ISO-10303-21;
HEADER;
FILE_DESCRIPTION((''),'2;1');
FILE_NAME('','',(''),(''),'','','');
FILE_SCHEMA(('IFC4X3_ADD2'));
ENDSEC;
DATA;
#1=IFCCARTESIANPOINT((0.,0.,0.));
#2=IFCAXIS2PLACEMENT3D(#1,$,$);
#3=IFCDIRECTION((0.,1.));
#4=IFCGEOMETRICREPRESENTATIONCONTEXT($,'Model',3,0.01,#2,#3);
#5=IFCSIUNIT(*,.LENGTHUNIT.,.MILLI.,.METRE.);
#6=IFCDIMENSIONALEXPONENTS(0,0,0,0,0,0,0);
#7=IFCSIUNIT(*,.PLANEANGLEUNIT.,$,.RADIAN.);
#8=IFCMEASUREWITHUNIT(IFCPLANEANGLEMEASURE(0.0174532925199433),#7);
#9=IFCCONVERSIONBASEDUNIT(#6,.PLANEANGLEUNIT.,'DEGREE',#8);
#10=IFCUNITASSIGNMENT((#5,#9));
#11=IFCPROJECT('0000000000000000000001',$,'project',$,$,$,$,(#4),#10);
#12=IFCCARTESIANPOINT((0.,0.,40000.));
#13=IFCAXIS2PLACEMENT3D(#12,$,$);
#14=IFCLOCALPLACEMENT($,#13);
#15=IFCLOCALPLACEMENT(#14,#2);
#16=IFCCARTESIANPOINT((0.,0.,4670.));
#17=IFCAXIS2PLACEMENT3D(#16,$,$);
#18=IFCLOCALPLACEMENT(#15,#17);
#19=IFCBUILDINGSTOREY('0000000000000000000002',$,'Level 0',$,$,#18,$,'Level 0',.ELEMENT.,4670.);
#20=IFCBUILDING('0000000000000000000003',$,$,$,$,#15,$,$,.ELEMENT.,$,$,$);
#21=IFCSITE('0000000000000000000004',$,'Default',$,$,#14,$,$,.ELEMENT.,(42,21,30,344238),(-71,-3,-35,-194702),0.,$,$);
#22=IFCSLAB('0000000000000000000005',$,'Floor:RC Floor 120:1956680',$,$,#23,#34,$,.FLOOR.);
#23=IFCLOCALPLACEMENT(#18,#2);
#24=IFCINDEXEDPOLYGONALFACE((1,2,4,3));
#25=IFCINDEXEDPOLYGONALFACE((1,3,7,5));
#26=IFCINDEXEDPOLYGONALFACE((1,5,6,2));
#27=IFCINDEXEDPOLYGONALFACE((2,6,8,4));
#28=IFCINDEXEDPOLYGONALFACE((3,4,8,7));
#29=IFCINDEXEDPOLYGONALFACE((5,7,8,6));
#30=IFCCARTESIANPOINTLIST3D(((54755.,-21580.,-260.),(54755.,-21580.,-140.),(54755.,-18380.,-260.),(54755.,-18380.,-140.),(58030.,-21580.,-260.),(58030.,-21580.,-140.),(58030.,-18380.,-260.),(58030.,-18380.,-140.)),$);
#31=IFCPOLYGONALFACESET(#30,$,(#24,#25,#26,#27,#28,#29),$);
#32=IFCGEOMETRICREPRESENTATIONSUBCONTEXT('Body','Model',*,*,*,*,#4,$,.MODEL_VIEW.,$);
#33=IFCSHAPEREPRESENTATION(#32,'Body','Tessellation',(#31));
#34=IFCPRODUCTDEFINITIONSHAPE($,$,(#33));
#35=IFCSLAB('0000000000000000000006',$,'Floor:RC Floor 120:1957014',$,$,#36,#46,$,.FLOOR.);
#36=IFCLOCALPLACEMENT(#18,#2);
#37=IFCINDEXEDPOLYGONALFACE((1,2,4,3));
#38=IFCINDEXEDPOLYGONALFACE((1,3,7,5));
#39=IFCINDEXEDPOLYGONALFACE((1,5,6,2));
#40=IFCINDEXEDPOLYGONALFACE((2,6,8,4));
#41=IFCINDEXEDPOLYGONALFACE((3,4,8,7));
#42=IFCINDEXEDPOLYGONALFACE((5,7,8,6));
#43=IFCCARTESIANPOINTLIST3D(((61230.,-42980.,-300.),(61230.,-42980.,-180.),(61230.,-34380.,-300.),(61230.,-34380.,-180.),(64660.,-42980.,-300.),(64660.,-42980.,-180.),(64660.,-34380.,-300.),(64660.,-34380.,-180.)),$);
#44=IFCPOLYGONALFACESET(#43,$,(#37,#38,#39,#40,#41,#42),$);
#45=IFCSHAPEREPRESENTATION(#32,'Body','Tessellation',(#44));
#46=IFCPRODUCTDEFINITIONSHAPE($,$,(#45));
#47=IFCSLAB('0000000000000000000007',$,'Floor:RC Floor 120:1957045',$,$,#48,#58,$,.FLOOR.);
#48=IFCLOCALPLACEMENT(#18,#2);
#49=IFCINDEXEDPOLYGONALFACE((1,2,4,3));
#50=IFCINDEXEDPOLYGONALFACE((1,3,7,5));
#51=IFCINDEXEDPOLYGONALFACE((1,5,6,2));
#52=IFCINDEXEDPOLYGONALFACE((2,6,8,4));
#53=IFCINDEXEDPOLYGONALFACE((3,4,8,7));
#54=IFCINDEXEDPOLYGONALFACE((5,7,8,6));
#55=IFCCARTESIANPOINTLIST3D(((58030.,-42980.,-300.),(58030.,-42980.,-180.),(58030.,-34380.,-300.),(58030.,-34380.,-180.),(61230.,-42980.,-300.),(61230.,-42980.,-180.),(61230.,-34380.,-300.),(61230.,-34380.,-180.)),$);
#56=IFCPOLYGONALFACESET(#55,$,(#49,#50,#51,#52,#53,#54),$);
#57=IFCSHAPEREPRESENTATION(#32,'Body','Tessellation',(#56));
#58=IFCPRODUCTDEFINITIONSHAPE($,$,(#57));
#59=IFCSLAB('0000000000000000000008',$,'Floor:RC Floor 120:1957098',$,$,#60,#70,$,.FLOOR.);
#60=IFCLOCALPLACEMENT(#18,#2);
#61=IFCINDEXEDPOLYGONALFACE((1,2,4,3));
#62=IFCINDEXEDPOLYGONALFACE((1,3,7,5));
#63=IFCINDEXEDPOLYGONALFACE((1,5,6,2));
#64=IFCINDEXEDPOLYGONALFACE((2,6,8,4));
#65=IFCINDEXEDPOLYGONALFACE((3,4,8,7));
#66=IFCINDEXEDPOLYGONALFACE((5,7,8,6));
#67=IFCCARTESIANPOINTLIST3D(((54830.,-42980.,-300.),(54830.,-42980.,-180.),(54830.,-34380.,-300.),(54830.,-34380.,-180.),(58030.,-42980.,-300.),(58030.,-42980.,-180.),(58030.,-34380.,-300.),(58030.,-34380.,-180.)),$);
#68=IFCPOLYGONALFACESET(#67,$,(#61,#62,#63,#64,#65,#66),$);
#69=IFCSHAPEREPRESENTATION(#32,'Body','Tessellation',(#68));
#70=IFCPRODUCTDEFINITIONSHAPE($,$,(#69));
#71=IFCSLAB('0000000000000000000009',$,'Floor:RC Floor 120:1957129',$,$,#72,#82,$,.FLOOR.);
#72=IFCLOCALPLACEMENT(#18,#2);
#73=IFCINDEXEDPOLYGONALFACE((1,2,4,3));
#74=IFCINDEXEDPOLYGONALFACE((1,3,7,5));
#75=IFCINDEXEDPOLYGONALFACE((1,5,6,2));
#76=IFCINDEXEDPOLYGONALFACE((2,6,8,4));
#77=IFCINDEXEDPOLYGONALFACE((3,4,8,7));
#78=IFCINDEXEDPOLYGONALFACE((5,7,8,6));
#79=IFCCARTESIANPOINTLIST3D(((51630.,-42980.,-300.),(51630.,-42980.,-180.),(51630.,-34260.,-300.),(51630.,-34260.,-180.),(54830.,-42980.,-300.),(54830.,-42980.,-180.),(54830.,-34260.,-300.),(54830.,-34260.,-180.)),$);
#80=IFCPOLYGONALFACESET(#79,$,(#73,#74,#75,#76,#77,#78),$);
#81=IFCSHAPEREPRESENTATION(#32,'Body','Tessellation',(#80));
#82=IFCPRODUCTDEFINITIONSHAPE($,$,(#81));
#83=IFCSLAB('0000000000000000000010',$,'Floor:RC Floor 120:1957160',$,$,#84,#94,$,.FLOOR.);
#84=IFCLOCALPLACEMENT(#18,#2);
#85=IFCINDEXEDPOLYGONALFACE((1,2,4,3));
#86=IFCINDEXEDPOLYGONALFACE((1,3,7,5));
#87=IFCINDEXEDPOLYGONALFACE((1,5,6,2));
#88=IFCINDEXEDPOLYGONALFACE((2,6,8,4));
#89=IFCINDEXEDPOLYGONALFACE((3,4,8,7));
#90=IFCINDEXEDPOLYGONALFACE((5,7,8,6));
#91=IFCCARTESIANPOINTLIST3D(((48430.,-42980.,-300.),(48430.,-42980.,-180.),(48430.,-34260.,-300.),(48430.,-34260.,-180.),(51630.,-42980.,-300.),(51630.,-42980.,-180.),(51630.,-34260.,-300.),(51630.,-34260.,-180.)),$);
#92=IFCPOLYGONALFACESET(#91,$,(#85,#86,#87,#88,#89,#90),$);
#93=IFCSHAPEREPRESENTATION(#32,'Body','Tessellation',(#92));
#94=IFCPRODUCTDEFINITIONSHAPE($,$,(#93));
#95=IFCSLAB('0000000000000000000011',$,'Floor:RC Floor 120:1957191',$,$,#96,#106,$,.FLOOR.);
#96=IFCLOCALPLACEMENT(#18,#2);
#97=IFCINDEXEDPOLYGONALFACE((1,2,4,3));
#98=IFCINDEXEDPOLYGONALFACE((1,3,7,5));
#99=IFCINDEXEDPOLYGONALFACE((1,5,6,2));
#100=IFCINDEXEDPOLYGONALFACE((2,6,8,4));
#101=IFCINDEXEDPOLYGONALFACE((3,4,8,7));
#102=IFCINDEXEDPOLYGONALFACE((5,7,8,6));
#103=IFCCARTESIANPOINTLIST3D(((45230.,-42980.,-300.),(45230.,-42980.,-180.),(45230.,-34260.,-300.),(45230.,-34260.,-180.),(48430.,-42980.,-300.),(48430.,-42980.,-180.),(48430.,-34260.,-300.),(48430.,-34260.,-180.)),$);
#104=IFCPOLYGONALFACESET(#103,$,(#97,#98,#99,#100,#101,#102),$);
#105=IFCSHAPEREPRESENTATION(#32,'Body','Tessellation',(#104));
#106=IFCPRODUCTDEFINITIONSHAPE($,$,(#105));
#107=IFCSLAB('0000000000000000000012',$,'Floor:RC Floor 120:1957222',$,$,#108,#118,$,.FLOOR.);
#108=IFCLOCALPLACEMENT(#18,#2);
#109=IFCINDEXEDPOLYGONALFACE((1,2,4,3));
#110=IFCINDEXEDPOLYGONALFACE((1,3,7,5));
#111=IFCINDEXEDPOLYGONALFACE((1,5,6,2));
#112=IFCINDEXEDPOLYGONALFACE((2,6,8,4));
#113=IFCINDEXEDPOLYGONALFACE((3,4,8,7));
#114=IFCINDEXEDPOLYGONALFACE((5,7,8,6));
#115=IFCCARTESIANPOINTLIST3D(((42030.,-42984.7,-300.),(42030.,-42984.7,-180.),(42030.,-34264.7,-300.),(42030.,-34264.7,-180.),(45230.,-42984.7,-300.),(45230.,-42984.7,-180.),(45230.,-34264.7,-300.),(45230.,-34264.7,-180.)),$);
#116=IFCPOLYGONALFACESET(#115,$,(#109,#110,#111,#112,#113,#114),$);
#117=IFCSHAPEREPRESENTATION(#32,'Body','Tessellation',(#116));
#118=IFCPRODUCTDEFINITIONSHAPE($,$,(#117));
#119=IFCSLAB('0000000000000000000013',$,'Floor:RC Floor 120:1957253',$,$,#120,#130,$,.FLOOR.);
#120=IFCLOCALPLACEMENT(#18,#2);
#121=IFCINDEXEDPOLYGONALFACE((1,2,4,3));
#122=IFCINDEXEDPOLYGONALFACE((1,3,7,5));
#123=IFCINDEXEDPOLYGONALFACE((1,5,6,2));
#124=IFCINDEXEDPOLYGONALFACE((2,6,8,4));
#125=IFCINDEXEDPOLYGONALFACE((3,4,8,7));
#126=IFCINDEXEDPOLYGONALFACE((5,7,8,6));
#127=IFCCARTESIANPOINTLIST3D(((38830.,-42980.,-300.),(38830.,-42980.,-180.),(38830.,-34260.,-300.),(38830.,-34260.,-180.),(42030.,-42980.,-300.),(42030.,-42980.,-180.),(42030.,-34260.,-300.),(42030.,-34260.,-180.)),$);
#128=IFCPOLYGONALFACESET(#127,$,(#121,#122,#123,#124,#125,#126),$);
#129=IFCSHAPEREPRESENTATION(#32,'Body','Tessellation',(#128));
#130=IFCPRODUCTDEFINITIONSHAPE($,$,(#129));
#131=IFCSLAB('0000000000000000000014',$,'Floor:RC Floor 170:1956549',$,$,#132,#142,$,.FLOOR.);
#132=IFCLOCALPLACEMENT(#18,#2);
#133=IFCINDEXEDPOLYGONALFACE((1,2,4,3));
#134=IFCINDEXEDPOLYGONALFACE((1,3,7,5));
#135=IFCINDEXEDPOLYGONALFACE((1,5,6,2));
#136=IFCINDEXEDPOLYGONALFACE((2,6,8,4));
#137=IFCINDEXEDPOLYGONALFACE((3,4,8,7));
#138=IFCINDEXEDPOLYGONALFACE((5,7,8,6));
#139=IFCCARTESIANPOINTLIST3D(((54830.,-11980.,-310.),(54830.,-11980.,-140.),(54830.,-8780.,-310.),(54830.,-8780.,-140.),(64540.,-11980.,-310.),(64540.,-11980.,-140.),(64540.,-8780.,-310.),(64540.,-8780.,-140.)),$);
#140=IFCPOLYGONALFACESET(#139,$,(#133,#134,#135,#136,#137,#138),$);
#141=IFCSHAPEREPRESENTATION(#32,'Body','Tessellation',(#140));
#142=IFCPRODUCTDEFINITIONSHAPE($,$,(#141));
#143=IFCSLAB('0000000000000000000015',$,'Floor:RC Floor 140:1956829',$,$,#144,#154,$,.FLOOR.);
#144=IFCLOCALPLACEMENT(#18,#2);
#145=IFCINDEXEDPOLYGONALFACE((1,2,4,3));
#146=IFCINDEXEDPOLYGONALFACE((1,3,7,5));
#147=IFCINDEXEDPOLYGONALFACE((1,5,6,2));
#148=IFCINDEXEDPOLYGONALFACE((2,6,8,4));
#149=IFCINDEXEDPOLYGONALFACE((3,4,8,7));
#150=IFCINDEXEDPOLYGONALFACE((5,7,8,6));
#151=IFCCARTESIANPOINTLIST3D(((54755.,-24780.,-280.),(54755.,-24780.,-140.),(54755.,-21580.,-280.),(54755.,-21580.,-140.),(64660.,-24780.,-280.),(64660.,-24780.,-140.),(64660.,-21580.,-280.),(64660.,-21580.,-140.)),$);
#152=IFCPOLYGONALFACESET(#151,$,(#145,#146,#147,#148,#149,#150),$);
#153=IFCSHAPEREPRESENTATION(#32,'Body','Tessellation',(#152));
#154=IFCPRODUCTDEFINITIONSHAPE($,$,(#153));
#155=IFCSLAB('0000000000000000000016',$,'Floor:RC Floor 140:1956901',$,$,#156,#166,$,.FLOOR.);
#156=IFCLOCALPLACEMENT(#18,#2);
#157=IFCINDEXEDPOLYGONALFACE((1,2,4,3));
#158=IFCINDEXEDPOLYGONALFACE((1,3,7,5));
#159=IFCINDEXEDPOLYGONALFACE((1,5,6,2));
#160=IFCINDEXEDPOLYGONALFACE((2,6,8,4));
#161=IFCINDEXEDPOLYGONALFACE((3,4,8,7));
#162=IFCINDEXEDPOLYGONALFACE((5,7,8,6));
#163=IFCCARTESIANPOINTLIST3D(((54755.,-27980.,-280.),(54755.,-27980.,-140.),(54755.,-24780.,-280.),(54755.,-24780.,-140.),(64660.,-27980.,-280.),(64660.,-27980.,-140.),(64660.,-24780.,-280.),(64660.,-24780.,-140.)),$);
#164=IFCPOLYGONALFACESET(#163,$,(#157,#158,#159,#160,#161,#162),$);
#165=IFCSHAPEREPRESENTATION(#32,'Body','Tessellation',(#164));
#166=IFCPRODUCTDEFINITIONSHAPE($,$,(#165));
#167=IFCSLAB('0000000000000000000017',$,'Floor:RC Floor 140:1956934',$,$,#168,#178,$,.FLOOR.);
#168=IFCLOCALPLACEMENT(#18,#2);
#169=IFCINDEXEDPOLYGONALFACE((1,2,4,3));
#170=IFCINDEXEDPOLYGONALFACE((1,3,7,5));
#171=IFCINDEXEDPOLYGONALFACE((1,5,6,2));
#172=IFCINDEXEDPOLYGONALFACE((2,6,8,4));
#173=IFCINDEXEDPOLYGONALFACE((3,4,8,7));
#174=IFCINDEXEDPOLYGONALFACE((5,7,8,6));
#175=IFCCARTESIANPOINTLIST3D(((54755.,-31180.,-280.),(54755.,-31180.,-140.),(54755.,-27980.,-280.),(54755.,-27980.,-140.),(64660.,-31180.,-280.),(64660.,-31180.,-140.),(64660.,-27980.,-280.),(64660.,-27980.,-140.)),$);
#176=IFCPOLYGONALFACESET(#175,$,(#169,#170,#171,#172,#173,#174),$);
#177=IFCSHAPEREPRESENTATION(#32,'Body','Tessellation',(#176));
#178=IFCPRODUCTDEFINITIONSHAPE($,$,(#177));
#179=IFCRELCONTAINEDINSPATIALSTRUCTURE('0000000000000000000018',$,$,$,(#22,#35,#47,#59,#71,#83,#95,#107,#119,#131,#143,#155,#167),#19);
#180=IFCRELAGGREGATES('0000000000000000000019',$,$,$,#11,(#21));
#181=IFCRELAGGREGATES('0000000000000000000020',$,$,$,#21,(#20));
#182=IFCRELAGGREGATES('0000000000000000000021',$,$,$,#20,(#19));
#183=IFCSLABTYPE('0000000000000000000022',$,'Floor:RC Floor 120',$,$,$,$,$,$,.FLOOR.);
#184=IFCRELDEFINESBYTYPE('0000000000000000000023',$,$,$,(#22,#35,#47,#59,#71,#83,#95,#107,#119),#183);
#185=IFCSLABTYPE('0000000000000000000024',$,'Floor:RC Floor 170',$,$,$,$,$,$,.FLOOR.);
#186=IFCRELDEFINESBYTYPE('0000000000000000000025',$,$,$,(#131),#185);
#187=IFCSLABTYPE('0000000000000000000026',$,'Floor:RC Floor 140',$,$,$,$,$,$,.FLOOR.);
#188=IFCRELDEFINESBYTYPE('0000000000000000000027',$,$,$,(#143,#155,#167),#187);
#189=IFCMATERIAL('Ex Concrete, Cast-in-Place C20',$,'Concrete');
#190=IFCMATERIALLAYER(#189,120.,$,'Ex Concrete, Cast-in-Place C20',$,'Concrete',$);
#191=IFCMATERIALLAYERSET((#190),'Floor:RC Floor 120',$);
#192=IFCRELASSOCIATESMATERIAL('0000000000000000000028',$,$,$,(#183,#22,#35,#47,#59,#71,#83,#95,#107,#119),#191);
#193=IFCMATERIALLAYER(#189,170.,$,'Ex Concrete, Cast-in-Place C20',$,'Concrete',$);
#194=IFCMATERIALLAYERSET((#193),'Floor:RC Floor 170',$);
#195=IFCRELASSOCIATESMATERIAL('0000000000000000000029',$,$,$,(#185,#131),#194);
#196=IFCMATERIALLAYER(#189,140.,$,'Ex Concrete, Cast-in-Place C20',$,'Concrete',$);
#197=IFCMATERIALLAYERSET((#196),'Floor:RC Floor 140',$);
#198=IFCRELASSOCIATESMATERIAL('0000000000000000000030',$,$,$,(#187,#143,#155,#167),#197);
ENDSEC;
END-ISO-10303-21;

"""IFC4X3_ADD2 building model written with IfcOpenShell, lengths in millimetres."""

from ifc_helpers import new_model, entity, si_unit, converted_unit, direction, frame, frame_2d, origin, origin_2d_with_axis, place, context, subcontext, project, spatial, rectangle, extrude, material, layer, layer_set, layer_usage, type_object, element, save


model = new_model("IFC4X3_ADD2")

# Units and contexts
model_context = context("Model", 3, precision=0.01, world=origin(), true_north=direction((0.0, 1.0)))
body_context = subcontext(model_context, "Body", "Model", "MODEL_VIEW")
ifc_project = project(units=[si_unit("LENGTHUNIT", "METRE", prefix="MILLI"), converted_unit("PLANEANGLEUNIT", "DEGREE", entity("IfcPlaneAngleMeasure", 0.0174532925199433), si_unit("PLANEANGLEUNIT", "RADIAN"), dimensions=[0, 0, 0, 0, 0, 0, 0])], contexts=[model_context])

# Site, building, storey
site_placement = place(None, frame((0.0, 0.0, 40000.0)))
site = spatial("IfcSite", under=ifc_project, at=site_placement, Name="Default", CompositionType="ELEMENT", RefLatitude=(42, 21, 30, 344238), RefLongitude=(-71, -3, -35, -194702), RefElevation=0.0)
building_placement = place(site_placement, origin())
building = spatial("IfcBuilding", under=site, at=building_placement, CompositionType="ELEMENT")
storey_placement = place(building_placement, frame((0.0, 0.0, 4670.0)))
storey = spatial("IfcBuildingStorey", under=building, at=storey_placement, Name="Level 0", LongName="Level 0", CompositionType="ELEMENT", Elevation=4670.0)

# Slabs
ifc_material_1 = material(Name="Ex Concrete, Cast-in-Place C20", Category="Concrete")
ifc_layer_1 = layer(ifc_material_1, 120.0, Name="Ex Concrete, Cast-in-Place C20", Category="Concrete")
ifc_layer_set_1 = layer_set([ifc_layer_1], Name="Floor:RC Floor 120")
slab_type_1 = type_object("IfcSlabType", Name="Floor:RC Floor 120", PredefinedType="FLOOR", material=ifc_layer_set_1)
ifc_layer_usage_1 = layer_usage(ifc_layer_set_1, "AXIS3", "POSITIVE", 0.0)
slab_1_placement = place(storey_placement, origin())
element("IfcSlab", 1, at=slab_1_placement, inside=storey, type_object=slab_type_1, material=ifc_layer_usage_1, Name="Floor:RC Floor 120:1956680", PredefinedType="FLOOR", context=body_context, shape_type="SweptSolid", body=[
    extrude(rectangle(XDim=3200.0, YDim=3275.0, at=frame_2d((0.0, 0.0), x_axis=(1.0, 0.0))), frame((56392.5, -19980.0, -140.0), z_axis=(0.0, 0.0, -1.0), x_axis=(0.0, 1.0, 0.0)), (0.0, 0.0, 1.0), 120.0),
])
ifc_layer_usage_2 = layer_usage(ifc_layer_set_1, "AXIS3", "POSITIVE", 0.0)
slab_2_placement = place(storey_placement, origin())
element("IfcSlab", 2, at=slab_2_placement, inside=storey, type_object=slab_type_1, material=ifc_layer_usage_2, Name="Floor:RC Floor 120:1957014", PredefinedType="FLOOR", context=body_context, shape_type="SweptSolid", body=[
    extrude(rectangle(XDim=8600.0, YDim=3430.0, at=frame_2d((0.0, 0.0), x_axis=(1.0, 0.0))), frame((62945.0, -38680.0, -180.0), z_axis=(0.0, 0.0, -1.0), x_axis=(0.0, 1.0, 0.0)), (0.0, 0.0, 1.0), 120.0),
])
ifc_layer_usage_3 = layer_usage(ifc_layer_set_1, "AXIS3", "POSITIVE", 0.0)
slab_3_placement = place(storey_placement, origin())
element("IfcSlab", 3, at=slab_3_placement, inside=storey, type_object=slab_type_1, material=ifc_layer_usage_3, Name="Floor:RC Floor 120:1957045", PredefinedType="FLOOR", context=body_context, shape_type="SweptSolid", body=[
    extrude(rectangle(XDim=8600.0, YDim=3200.0, at=frame_2d((0.0, 0.0), x_axis=(1.0, 0.0))), frame((59630.0, -38680.0, -180.0), z_axis=(0.0, 0.0, -1.0), x_axis=(0.0, 1.0, 0.0)), (0.0, 0.0, 1.0), 120.0),
])
ifc_layer_usage_4 = layer_usage(ifc_layer_set_1, "AXIS3", "POSITIVE", 0.0)
slab_4_placement = place(storey_placement, origin())
element("IfcSlab", 4, at=slab_4_placement, inside=storey, type_object=slab_type_1, material=ifc_layer_usage_4, Name="Floor:RC Floor 120:1957098", PredefinedType="FLOOR", context=body_context, shape_type="SweptSolid", body=[
    extrude(rectangle(XDim=8600.0, YDim=3200.0, at=frame_2d((0.0, 0.0), x_axis=(1.0, 0.0))), frame((56430.0, -38680.0, -180.0), z_axis=(0.0, 0.0, -1.0), x_axis=(0.0, 1.0, 0.0)), (0.0, 0.0, 1.0), 120.0),
])
ifc_layer_usage_5 = layer_usage(ifc_layer_set_1, "AXIS3", "POSITIVE", 0.0)
slab_5_placement = place(storey_placement, origin())
element("IfcSlab", 5, at=slab_5_placement, inside=storey, type_object=slab_type_1, material=ifc_layer_usage_5, Name="Floor:RC Floor 120:1957129", PredefinedType="FLOOR", context=body_context, shape_type="SweptSolid", body=[
    extrude(rectangle(XDim=8720.0, YDim=3200.0, at=frame_2d((0.0, 0.0), x_axis=(1.0, 0.0))), frame((53230.0, -38620.0, -180.0), z_axis=(0.0, 0.0, -1.0), x_axis=(0.0, 1.0, 0.0)), (0.0, 0.0, 1.0), 120.0),
])
ifc_layer_usage_6 = layer_usage(ifc_layer_set_1, "AXIS3", "POSITIVE", 0.0)
slab_6_placement = place(storey_placement, origin())
element("IfcSlab", 6, at=slab_6_placement, inside=storey, type_object=slab_type_1, material=ifc_layer_usage_6, Name="Floor:RC Floor 120:1957160", PredefinedType="FLOOR", context=body_context, shape_type="SweptSolid", body=[
    extrude(rectangle(XDim=8720.0, YDim=3200.0, at=origin_2d_with_axis()), frame((50030.0, -38620.0, -180.0), z_axis=(0.0, 0.0, -1.0), x_axis=(0.0, 1.0, 0.0)), (0.0, 0.0, 1.0), 120.0),
])
ifc_layer_usage_7 = layer_usage(ifc_layer_set_1, "AXIS3", "POSITIVE", 0.0)
slab_7_placement = place(storey_placement, origin())
element("IfcSlab", 7, at=slab_7_placement, inside=storey, type_object=slab_type_1, material=ifc_layer_usage_7, Name="Floor:RC Floor 120:1957191", PredefinedType="FLOOR", context=body_context, shape_type="SweptSolid", body=[
    extrude(rectangle(XDim=8720.0, YDim=3200.0, at=frame_2d((0.0, 0.0), x_axis=(1.0, 0.0))), frame((46830.0, -38620.0, -180.0), z_axis=(0.0, 0.0, -1.0), x_axis=(0.0, 1.0, 0.0)), (0.0, 0.0, 1.0), 120.0),
])
ifc_layer_usage_8 = layer_usage(ifc_layer_set_1, "AXIS3", "POSITIVE", 0.0)
slab_8_placement = place(storey_placement, origin())
element("IfcSlab", 8, at=slab_8_placement, inside=storey, type_object=slab_type_1, material=ifc_layer_usage_8, Name="Floor:RC Floor 120:1957222", PredefinedType="FLOOR", context=body_context, shape_type="SweptSolid", body=[
    extrude(rectangle(XDim=8720.0, YDim=3200.0, at=frame_2d((0.0, 0.0), x_axis=(1.0, 0.0))), frame((43630.0, -38624.7, -180.0), z_axis=(0.0, 0.0, -1.0), x_axis=(0.0, 1.0, 0.0)), (0.0, 0.0, 1.0), 120.0),
])
ifc_layer_usage_9 = layer_usage(ifc_layer_set_1, "AXIS3", "POSITIVE", 0.0)
slab_9_placement = place(storey_placement, origin())
element("IfcSlab", 9, at=slab_9_placement, inside=storey, type_object=slab_type_1, material=ifc_layer_usage_9, Name="Floor:RC Floor 120:1957253", PredefinedType="FLOOR", context=body_context, shape_type="SweptSolid", body=[
    extrude(rectangle(XDim=8720.0, YDim=3200.0, at=frame_2d((0.0, 0.0), x_axis=(1.0, 0.0))), frame((40430.0, -38620.0, -180.0), z_axis=(0.0, 0.0, -1.0), x_axis=(0.0, 1.0, 0.0)), (0.0, 0.0, 1.0), 120.0),
])
ifc_layer_2 = layer(ifc_material_1, 170.0, Name="Ex Concrete, Cast-in-Place C20", Category="Concrete")
ifc_layer_set_2 = layer_set([ifc_layer_2], Name="Floor:RC Floor 170")
ifc_layer_usage_10 = layer_usage(ifc_layer_set_2, "AXIS3", "POSITIVE", 0.0)
slab_type_2 = type_object("IfcSlabType", Name="Floor:RC Floor 170", PredefinedType="FLOOR", material=ifc_layer_set_2)
slab_10_placement = place(storey_placement, origin())
element("IfcSlab", 10, at=slab_10_placement, inside=storey, type_object=slab_type_2, material=ifc_layer_usage_10, Name="Floor:RC Floor 170:1956549", PredefinedType="FLOOR", context=body_context, shape_type="SweptSolid", body=[
    extrude(rectangle(XDim=3200.0, YDim=9710.0, at=frame_2d((0.0, 0.0), x_axis=(1.0, 0.0))), frame((59685.0, -10380.0, -140.0), z_axis=(0.0, 0.0, -1.0), x_axis=(0.0, 1.0, 0.0)), (0.0, 0.0, 1.0), 170.0),
])
ifc_layer_3 = layer(ifc_material_1, 140.0, Name="Ex Concrete, Cast-in-Place C20", Category="Concrete")
ifc_layer_set_3 = layer_set([ifc_layer_3], Name="Floor:RC Floor 140")
ifc_layer_usage_11 = layer_usage(ifc_layer_set_3, "AXIS3", "POSITIVE", 0.0)
slab_type_3 = type_object("IfcSlabType", Name="Floor:RC Floor 140", PredefinedType="FLOOR", material=ifc_layer_set_3)
slab_11_placement = place(storey_placement, origin())
element("IfcSlab", 11, at=slab_11_placement, inside=storey, type_object=slab_type_3, material=ifc_layer_usage_11, Name="Floor:RC Floor 140:1956829", PredefinedType="FLOOR", context=body_context, shape_type="SweptSolid", body=[
    extrude(rectangle(XDim=3200.0, YDim=9905.0, at=frame_2d((0.0, 0.0), x_axis=(1.0, 0.0))), frame((59707.5, -23180.0, -140.0), z_axis=(0.0, 0.0, -1.0), x_axis=(0.0, 1.0, 0.0)), (0.0, 0.0, 1.0), 140.0),
])
ifc_layer_usage_12 = layer_usage(ifc_layer_set_3, "AXIS3", "POSITIVE", 0.0)
slab_12_placement = place(storey_placement, origin())
element("IfcSlab", 12, at=slab_12_placement, inside=storey, type_object=slab_type_3, material=ifc_layer_usage_12, Name="Floor:RC Floor 140:1956901", PredefinedType="FLOOR", context=body_context, shape_type="SweptSolid", body=[
    extrude(rectangle(XDim=3200.0, YDim=9905.0, at=frame_2d((0.0, 0.0), x_axis=(1.0, 0.0))), frame((59707.5, -26380.0, -140.0), z_axis=(0.0, 0.0, -1.0), x_axis=(0.0, 1.0, 0.0)), (0.0, 0.0, 1.0), 140.0),
])
ifc_layer_usage_13 = layer_usage(ifc_layer_set_3, "AXIS3", "POSITIVE", 0.0)
slab_13_placement = place(storey_placement, origin())
element("IfcSlab", 13, at=slab_13_placement, inside=storey, type_object=slab_type_3, material=ifc_layer_usage_13, Name="Floor:RC Floor 140:1956934", PredefinedType="FLOOR", context=body_context, shape_type="SweptSolid", body=[
    extrude(rectangle(XDim=3200.0, YDim=9905.0, at=frame_2d((0.0, 0.0), x_axis=(1.0, 0.0))), frame((59707.5, -29580.0, -140.0), z_axis=(0.0, 0.0, -1.0), x_axis=(0.0, 1.0, 0.0)), (0.0, 0.0, 1.0), 140.0),
])

save(model, "model.ifc")
